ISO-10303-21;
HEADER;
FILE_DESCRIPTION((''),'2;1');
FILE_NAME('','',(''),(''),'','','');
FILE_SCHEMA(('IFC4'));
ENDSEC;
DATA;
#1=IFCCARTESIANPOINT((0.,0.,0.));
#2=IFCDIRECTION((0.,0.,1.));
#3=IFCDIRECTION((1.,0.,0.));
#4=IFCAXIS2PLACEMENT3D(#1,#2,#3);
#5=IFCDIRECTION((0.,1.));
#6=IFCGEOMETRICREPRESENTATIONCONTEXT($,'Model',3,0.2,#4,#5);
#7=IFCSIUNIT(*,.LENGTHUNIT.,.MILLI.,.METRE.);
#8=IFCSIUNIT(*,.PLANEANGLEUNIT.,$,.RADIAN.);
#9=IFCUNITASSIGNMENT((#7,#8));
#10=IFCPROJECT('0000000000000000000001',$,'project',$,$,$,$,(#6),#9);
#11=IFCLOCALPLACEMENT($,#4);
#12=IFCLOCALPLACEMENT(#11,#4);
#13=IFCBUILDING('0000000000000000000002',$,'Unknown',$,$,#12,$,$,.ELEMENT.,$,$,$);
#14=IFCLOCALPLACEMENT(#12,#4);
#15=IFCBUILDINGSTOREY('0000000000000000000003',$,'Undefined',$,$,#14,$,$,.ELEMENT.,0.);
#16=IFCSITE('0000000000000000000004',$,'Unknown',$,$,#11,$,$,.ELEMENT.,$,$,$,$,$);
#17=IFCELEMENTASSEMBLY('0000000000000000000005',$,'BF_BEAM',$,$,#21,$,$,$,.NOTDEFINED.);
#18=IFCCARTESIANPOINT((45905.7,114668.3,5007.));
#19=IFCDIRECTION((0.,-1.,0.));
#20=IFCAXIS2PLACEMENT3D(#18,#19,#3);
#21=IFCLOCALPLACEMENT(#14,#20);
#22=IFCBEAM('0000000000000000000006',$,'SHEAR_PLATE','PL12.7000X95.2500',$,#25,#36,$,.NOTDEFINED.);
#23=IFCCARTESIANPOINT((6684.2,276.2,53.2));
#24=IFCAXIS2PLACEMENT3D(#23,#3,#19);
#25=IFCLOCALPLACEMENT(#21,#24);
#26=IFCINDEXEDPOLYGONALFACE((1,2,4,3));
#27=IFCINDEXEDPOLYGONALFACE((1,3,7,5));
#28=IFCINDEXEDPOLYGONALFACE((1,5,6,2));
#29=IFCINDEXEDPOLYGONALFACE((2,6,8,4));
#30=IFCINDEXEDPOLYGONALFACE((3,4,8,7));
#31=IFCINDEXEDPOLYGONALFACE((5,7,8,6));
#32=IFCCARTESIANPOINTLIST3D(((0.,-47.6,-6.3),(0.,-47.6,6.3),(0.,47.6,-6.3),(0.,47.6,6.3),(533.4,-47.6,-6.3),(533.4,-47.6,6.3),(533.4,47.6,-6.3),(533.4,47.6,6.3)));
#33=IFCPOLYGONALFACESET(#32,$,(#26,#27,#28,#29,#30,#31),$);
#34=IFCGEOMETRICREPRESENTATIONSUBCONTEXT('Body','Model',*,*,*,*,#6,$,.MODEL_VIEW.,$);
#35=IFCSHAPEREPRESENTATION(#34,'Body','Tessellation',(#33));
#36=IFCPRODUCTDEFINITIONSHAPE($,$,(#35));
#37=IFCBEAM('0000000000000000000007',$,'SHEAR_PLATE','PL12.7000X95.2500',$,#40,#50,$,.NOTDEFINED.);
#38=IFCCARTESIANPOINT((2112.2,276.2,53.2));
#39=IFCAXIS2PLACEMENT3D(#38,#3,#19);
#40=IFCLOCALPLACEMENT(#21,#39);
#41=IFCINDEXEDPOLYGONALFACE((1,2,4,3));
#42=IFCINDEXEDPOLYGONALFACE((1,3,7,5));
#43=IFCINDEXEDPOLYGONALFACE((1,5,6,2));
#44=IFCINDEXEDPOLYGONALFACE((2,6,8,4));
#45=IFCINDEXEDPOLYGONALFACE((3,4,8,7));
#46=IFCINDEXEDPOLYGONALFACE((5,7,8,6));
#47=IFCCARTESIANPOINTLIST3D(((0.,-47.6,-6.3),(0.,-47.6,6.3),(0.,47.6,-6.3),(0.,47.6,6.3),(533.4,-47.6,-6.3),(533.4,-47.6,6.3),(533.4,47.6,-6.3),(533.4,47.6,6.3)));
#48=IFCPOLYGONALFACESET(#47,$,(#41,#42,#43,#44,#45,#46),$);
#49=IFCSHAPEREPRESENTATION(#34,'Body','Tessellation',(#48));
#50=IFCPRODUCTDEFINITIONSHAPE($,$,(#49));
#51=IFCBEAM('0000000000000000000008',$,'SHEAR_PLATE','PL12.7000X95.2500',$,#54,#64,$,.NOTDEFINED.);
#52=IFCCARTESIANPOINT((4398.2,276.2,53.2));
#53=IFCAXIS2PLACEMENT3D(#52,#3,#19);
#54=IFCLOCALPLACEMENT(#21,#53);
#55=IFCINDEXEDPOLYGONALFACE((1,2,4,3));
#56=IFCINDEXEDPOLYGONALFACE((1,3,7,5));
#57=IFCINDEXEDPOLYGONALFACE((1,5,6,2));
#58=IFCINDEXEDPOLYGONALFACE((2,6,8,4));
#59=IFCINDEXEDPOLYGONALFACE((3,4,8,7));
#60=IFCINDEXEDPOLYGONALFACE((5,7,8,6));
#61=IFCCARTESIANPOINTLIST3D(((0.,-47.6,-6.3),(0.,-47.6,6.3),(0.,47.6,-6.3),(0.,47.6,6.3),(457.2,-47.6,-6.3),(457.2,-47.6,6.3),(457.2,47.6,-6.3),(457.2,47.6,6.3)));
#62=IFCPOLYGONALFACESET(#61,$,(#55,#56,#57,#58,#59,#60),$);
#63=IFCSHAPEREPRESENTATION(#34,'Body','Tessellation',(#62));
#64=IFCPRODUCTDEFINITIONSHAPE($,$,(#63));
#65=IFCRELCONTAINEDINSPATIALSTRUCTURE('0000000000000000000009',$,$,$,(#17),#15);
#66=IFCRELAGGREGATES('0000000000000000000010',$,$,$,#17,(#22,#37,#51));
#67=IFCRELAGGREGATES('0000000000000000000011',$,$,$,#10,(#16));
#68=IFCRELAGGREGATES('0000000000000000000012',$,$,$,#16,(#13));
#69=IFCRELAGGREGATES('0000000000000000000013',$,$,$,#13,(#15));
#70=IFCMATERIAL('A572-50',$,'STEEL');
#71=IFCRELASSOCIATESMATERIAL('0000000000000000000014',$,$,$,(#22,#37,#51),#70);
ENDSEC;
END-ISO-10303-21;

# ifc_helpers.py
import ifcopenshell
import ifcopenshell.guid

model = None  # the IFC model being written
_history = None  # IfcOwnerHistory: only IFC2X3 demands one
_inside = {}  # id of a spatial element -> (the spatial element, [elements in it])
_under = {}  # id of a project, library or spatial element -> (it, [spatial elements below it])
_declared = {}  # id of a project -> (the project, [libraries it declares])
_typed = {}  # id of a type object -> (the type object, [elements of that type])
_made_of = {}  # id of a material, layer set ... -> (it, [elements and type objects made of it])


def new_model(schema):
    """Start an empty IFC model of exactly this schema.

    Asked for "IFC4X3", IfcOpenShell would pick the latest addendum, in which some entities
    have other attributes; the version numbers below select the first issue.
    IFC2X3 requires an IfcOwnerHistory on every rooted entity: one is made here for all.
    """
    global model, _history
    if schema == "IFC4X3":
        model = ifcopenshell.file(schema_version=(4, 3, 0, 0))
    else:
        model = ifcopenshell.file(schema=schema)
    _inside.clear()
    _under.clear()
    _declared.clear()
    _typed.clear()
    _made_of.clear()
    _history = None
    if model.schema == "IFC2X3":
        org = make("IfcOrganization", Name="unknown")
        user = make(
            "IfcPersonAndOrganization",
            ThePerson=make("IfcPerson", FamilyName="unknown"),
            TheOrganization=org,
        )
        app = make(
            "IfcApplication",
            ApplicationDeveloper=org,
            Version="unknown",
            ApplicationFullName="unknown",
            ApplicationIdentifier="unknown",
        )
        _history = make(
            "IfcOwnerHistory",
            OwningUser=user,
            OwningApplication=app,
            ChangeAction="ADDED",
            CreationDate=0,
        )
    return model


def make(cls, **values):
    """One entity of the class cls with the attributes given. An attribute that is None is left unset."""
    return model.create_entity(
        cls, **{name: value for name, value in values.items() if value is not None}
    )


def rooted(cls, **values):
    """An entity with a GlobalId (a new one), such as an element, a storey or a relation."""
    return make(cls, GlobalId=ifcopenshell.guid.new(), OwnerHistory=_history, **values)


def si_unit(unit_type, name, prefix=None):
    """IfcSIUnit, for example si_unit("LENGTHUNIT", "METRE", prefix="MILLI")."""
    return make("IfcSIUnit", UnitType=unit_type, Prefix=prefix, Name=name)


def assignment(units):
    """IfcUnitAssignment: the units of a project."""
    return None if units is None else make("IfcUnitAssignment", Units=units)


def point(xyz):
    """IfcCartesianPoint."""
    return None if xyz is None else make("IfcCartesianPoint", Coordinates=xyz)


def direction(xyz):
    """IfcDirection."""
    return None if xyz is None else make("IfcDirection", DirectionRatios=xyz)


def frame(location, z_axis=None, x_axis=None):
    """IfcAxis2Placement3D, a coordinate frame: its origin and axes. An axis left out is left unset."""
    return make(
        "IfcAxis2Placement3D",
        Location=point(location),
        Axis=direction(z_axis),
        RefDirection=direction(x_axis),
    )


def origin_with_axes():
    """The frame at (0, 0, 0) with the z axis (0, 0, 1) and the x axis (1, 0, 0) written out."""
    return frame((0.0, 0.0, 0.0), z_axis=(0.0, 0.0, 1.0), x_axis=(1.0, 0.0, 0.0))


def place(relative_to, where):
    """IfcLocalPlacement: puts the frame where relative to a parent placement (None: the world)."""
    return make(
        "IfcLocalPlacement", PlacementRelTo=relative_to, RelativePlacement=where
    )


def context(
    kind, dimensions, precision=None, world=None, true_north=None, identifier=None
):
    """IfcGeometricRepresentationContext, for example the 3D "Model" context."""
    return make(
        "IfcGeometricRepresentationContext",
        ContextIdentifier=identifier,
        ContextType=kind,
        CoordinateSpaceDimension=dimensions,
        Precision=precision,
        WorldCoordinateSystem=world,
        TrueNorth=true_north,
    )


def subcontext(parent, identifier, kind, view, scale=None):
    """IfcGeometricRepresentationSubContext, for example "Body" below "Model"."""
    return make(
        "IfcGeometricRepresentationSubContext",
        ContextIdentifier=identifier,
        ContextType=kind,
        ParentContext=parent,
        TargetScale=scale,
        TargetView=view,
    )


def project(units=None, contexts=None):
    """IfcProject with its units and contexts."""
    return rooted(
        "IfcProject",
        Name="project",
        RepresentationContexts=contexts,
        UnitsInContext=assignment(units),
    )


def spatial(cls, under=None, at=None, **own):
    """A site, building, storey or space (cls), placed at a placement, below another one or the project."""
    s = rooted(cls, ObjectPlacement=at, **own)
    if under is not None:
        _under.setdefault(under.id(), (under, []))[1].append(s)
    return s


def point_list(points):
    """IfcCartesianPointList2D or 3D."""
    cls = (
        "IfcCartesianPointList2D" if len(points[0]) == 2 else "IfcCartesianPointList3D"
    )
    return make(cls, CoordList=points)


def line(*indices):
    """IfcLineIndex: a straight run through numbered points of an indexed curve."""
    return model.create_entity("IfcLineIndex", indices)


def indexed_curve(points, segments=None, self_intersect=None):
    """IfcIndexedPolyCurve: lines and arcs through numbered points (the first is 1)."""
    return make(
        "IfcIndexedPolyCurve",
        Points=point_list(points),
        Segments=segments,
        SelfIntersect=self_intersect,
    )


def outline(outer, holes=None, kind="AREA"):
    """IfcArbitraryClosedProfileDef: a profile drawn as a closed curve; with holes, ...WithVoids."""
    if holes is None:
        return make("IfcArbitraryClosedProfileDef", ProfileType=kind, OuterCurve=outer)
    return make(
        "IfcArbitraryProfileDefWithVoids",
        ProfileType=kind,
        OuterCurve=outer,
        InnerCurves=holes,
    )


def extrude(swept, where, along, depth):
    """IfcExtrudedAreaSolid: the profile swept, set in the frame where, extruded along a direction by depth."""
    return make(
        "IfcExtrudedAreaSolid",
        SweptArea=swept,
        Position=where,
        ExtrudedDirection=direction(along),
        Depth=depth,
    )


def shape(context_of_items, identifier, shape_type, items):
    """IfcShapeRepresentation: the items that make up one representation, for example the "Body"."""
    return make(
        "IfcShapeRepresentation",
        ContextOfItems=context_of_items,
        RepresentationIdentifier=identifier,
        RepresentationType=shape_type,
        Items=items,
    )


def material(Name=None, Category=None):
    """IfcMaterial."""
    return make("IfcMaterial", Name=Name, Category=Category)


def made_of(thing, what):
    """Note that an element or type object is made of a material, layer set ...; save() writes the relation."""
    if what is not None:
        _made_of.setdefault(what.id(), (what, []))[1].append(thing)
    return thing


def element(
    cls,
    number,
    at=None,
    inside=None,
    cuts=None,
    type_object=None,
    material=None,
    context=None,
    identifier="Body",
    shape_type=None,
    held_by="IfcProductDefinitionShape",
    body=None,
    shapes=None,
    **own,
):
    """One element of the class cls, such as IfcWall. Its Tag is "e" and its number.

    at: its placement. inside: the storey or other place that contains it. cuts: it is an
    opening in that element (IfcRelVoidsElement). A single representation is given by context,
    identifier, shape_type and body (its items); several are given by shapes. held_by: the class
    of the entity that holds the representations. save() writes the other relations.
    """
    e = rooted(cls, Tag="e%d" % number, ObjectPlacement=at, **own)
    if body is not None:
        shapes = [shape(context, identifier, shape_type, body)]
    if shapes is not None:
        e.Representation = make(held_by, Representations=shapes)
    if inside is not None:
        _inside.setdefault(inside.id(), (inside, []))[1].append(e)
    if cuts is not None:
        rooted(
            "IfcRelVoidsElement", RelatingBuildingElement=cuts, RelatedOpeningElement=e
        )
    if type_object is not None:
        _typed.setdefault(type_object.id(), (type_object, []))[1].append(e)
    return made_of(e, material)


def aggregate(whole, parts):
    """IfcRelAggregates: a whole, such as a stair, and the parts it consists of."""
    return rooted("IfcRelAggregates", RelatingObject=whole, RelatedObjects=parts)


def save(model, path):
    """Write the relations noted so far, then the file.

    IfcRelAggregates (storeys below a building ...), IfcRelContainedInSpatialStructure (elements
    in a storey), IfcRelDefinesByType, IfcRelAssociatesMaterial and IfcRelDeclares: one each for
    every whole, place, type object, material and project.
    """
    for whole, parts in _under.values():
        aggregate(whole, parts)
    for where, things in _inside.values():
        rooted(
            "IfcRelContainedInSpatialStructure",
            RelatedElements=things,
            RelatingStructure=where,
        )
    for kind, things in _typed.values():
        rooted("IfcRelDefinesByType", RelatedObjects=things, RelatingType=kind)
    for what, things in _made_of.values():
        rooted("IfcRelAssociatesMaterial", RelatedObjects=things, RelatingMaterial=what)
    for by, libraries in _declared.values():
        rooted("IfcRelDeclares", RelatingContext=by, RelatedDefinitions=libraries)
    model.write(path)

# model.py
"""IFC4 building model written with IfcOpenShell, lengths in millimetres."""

from ifc_helpers import new_model, si_unit, direction, frame, origin_with_axes, place, context, subcontext, project, spatial, line, indexed_curve, outline, extrude, material, element, aggregate, save


model = new_model("IFC4")

# Units and contexts
model_context = context("Model", 3, precision=0.2, world=origin_with_axes(), true_north=direction((0.0, 1.0)))
body_context = subcontext(model_context, "Body", "Model", "MODEL_VIEW")
ifc_project = project(units=[si_unit("LENGTHUNIT", "METRE", prefix="MILLI"), si_unit("PLANEANGLEUNIT", "RADIAN")], contexts=[model_context])

# Site, building, storey
site_placement = place(None, origin_with_axes())
site = spatial("IfcSite", under=ifc_project, at=site_placement, Name="Unknown", CompositionType="ELEMENT")
building_placement = place(site_placement, origin_with_axes())
building = spatial("IfcBuilding", under=site, at=building_placement, Name="Unknown", CompositionType="ELEMENT")
storey_placement = place(building_placement, origin_with_axes())
storey = spatial("IfcBuildingStorey", under=building, at=storey_placement, Name="Undefined", CompositionType="ELEMENT", Elevation=0.0)

# Element assembly, beams
assembly_1_placement = place(storey_placement, frame((45905.7, 114668.3, 5007.0), z_axis=(0.0, -1.0, 0.0), x_axis=(1.0, 0.0, 0.0)))
assembly_1 = element("IfcElementAssembly", 1, at=assembly_1_placement, inside=storey, Name="BF_BEAM", PredefinedType="NOTDEFINED")
ifc_material_1 = material(Name="A572-50", Category="STEEL")
beam_1_placement = place(assembly_1_placement, frame((6684.2, 276.2, 53.2), z_axis=(1.0, 0.0, 0.0), x_axis=(0.0, -1.0, 0.0)))
beam_1 = element("IfcBeam", 2, at=beam_1_placement, material=ifc_material_1, Name="SHEAR_PLATE", Description="PL12.7000X95.2500", PredefinedType="NOTDEFINED", context=body_context, shape_type="SolidModel", body=[
    extrude(outline(indexed_curve([(-6.3, -47.6), (6.3, -47.6), (6.3, 47.6), (-6.3, 47.6)], segments=[line(1, 2, 3, 4, 1)])), frame((0.0, 0.0, 0.0), z_axis=(-1.0, 0.0, 0.0), x_axis=(0.0, 0.0, 1.0)), (0.0, 0.0, -1.0), 533.4),
])
beam_2_placement = place(assembly_1_placement, frame((2112.2, 276.2, 53.2), z_axis=(1.0, 0.0, 0.0), x_axis=(0.0, -1.0, 0.0)))
beam_2 = element("IfcBeam", 3, at=beam_2_placement, material=ifc_material_1, Name="SHEAR_PLATE", Description="PL12.7000X95.2500", PredefinedType="NOTDEFINED", context=body_context, shape_type="SolidModel", body=[
    extrude(outline(indexed_curve([(-6.3, -47.6), (6.3, -47.6), (6.3, 47.6), (-6.3, 47.6)], segments=[line(1, 2, 3, 4, 1)])), frame((0.0, 0.0, 0.0), z_axis=(-1.0, 0.0, 0.0), x_axis=(0.0, 0.0, 1.0)), (0.0, 0.0, -1.0), 533.4),
])
beam_3_placement = place(assembly_1_placement, frame((4398.2, 276.2, 53.2), z_axis=(1.0, 0.0, 0.0), x_axis=(0.0, -1.0, 0.0)))
beam_3 = element("IfcBeam", 4, at=beam_3_placement, material=ifc_material_1, Name="SHEAR_PLATE", Description="PL12.7000X95.2500", PredefinedType="NOTDEFINED", context=body_context, shape_type="SolidModel", body=[
    extrude(outline(indexed_curve([(-6.3, -47.6), (6.3, -47.6), (6.3, 47.6), (-6.3, 47.6)], segments=[line(1, 2, 3, 4, 1)])), frame((0.0, 0.0, 0.0), z_axis=(-1.0, 0.0, 0.0), x_axis=(0.0, 0.0, 1.0)), (0.0, 0.0, -1.0), 457.2),
])
aggregate(assembly_1, [beam_1, beam_2, beam_3])

save(model, "model.ifc")
